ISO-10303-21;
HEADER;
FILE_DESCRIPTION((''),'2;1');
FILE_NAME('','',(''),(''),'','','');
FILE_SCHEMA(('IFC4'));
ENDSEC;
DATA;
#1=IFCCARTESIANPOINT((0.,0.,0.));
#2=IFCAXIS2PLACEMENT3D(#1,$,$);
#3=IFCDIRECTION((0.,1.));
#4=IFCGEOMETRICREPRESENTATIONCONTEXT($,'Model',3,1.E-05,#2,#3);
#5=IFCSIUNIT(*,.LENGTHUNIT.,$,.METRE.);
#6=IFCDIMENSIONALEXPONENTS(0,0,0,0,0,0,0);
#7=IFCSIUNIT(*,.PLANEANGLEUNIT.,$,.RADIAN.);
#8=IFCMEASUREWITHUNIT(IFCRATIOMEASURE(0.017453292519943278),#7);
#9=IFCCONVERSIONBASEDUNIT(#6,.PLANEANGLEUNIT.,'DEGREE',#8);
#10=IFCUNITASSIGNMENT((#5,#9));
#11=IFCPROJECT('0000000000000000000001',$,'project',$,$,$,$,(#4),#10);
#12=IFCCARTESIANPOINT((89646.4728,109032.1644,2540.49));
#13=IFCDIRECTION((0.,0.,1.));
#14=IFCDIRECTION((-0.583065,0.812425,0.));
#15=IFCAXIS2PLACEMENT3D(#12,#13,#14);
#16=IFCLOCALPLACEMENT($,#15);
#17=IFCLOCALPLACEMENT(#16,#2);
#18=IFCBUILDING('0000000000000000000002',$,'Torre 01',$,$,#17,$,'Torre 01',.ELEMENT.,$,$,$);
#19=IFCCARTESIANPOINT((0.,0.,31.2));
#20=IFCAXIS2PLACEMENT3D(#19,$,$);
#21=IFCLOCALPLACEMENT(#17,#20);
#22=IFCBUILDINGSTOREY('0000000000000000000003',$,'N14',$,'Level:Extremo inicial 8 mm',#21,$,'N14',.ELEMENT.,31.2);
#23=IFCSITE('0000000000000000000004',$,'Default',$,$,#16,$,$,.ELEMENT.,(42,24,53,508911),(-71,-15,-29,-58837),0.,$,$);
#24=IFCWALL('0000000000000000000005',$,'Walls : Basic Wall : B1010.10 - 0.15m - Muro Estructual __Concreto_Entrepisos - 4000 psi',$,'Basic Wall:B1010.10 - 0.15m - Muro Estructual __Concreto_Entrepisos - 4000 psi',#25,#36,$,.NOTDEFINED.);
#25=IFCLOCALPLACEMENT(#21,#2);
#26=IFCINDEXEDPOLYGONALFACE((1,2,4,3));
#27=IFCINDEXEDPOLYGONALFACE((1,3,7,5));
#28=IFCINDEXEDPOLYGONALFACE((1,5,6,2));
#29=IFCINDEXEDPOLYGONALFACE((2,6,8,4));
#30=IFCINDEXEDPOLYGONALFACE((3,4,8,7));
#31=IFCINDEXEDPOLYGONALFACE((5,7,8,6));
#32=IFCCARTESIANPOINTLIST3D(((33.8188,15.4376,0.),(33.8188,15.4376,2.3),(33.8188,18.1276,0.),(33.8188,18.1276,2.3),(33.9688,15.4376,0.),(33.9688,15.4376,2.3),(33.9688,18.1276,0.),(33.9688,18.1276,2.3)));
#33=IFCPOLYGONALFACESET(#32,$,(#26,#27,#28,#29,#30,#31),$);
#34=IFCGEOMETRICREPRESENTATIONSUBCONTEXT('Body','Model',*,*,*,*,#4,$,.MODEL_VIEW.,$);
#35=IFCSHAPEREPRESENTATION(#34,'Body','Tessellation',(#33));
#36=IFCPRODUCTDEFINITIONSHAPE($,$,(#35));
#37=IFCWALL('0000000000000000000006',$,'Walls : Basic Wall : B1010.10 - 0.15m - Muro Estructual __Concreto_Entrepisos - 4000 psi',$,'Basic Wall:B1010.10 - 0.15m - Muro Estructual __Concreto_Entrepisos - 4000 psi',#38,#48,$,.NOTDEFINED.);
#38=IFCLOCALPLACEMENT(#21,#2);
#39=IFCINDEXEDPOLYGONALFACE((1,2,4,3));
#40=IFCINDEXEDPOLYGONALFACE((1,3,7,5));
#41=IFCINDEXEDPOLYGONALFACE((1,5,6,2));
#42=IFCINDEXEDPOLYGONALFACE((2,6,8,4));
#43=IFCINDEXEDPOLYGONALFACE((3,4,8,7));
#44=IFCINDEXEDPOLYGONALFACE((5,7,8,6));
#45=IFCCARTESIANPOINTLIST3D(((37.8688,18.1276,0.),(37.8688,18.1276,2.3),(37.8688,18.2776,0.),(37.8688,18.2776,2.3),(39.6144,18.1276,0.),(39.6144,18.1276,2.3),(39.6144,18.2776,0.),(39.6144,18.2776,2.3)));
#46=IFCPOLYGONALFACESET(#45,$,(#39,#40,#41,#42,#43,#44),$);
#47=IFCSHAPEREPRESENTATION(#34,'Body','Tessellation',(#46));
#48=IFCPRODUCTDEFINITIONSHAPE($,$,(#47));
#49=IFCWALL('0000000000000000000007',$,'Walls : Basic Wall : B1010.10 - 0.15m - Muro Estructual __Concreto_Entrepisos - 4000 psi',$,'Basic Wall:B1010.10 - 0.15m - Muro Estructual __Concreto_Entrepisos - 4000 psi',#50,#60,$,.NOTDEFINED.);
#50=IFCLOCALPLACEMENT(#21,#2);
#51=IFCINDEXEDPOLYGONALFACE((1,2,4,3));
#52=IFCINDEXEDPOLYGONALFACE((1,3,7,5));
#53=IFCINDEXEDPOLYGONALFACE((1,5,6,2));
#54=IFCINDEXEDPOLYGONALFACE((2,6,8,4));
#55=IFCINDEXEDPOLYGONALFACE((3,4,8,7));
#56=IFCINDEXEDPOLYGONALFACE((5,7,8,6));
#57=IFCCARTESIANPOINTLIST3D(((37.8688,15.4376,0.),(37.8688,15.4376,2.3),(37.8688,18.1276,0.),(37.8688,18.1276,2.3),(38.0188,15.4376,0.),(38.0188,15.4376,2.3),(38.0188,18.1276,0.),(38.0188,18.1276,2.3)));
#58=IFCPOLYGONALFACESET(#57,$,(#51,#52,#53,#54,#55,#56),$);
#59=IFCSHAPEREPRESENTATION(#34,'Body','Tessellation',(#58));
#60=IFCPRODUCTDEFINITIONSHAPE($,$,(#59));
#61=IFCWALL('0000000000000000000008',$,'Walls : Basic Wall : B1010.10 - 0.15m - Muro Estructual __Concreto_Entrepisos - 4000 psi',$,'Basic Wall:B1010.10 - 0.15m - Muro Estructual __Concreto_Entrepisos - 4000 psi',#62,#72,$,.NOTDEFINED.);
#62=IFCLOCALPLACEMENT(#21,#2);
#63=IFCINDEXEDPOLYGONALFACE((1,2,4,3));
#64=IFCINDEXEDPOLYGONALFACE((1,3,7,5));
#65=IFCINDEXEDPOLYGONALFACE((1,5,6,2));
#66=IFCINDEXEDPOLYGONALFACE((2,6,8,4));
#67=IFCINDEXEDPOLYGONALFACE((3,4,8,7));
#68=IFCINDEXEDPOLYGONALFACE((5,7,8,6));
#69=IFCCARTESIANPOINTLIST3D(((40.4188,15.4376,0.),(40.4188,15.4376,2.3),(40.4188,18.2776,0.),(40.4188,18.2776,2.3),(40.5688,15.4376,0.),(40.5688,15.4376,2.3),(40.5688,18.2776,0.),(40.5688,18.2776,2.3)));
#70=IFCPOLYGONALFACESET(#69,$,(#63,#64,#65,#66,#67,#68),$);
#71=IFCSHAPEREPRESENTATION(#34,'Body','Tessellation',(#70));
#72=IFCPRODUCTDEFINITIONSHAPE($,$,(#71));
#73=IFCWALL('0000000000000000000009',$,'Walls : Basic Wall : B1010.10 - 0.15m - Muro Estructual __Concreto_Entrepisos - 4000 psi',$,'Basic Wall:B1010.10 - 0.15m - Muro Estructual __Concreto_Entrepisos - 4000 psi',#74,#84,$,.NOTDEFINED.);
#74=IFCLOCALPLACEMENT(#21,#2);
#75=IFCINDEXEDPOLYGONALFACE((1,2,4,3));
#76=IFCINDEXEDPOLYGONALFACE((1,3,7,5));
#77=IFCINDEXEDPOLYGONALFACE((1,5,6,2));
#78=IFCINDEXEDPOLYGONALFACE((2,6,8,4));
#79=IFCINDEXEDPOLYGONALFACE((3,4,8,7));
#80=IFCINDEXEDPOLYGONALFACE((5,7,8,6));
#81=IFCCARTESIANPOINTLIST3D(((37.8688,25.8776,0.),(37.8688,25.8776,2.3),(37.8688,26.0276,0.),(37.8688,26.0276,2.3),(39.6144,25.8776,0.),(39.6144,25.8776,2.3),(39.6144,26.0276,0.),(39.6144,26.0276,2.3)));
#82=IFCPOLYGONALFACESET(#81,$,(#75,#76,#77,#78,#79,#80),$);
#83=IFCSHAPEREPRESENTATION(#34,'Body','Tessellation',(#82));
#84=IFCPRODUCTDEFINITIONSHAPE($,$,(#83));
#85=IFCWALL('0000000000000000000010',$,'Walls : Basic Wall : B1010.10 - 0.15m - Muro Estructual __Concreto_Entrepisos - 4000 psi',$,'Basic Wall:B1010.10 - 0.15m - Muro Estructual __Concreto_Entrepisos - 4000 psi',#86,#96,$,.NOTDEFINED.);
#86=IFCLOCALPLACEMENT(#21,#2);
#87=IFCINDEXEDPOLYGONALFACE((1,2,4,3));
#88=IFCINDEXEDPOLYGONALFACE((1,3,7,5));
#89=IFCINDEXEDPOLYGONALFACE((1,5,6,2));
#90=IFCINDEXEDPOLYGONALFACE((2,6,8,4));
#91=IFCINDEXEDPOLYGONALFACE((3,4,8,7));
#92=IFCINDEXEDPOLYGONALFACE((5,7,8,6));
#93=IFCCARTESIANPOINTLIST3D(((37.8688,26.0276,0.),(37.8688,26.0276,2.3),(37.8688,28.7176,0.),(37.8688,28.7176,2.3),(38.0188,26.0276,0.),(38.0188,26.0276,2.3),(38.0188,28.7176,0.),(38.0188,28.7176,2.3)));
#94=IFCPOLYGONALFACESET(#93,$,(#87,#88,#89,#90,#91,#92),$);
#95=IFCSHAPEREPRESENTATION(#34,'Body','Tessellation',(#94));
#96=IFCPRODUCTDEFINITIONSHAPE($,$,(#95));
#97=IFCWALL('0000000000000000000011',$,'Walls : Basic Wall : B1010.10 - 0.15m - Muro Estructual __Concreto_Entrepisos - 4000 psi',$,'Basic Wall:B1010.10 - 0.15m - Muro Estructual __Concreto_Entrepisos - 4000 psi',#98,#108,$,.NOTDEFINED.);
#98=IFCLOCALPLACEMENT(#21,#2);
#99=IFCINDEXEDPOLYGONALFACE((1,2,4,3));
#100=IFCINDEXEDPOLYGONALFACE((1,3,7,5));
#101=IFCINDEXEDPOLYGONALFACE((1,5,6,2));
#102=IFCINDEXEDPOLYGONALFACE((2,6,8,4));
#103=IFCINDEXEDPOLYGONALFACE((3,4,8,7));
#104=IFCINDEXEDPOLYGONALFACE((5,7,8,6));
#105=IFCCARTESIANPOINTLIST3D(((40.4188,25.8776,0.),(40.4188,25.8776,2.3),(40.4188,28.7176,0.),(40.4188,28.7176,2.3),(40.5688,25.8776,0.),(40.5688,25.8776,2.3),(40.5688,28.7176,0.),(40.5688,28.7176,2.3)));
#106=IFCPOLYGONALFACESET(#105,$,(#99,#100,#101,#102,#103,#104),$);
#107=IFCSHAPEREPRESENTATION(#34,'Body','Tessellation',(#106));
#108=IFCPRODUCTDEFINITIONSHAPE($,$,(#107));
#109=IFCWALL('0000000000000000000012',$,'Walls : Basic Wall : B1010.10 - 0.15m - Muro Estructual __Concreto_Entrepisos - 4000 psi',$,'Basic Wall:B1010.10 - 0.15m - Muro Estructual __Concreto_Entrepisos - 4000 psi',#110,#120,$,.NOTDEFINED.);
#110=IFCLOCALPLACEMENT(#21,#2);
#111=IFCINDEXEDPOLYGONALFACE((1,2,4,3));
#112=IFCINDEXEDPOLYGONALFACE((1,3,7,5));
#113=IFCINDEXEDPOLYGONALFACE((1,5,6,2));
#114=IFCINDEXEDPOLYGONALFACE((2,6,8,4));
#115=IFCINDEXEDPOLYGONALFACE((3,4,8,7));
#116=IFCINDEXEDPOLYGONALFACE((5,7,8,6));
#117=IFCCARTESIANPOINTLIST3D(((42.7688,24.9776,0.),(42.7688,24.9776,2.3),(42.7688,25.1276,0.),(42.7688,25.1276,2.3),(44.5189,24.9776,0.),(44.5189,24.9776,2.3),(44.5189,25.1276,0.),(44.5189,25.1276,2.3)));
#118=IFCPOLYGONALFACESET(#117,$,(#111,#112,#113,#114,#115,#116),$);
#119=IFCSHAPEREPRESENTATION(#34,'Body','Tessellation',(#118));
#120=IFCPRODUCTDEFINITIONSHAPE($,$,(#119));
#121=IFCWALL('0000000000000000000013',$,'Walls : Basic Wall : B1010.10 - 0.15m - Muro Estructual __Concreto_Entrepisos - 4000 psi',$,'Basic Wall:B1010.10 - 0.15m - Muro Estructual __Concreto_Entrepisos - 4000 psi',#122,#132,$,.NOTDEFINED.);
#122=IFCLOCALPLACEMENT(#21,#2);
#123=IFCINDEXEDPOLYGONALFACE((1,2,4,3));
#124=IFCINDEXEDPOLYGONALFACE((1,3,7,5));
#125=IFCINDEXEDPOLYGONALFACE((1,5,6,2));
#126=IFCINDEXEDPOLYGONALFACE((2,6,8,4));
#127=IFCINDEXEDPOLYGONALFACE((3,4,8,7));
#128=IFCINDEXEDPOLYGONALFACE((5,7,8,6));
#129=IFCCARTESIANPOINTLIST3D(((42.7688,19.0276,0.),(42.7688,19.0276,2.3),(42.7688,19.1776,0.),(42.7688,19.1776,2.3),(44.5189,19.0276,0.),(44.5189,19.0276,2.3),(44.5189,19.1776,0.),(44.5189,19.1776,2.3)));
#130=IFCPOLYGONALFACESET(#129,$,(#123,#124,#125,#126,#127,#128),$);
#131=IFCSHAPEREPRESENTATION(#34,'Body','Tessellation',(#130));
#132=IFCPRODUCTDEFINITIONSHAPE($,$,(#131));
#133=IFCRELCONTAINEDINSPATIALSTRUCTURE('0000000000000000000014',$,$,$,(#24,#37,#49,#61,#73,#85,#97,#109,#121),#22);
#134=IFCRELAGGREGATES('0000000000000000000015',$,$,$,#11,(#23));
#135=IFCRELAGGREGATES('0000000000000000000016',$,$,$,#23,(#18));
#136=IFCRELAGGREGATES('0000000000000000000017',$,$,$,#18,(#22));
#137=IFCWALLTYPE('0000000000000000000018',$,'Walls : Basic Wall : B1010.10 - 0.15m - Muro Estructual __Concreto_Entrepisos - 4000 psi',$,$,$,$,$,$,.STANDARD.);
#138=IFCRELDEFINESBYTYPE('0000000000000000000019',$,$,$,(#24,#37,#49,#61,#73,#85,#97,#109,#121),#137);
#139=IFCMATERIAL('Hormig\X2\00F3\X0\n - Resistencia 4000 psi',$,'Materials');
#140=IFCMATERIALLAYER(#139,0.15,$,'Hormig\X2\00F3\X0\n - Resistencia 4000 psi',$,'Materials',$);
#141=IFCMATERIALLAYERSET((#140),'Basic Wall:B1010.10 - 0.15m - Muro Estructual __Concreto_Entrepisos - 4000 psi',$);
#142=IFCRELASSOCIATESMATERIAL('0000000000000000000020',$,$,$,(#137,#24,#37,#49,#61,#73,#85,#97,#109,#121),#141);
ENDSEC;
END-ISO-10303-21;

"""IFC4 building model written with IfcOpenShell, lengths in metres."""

from ifc_helpers import new_model, entity, si_unit, converted_unit, direction, frame, frame_2d, origin, place, context, subcontext, project, spatial, rectangle, extrude, material, layer, layer_set, layer_usage, type_object, element, save


model = new_model("IFC4")

# Units and contexts
model_context = context("Model", 3, precision=1e-05, world=origin(), true_north=direction((0.0, 1.0)))
body_context = subcontext(model_context, "Body", "Model", "MODEL_VIEW")
ifc_project = project(units=[si_unit("LENGTHUNIT", "METRE"), converted_unit("PLANEANGLEUNIT", "DEGREE", entity("IfcRatioMeasure", 0.017453292519943278), si_unit("PLANEANGLEUNIT", "RADIAN"), dimensions=[0, 0, 0, 0, 0, 0, 0])], contexts=[model_context])

# Site, building, storey
site_placement = place(None, frame((89646.4728, 109032.1644, 2540.49), z_axis=(0.0, 0.0, 1.0), x_axis=(-0.583065, 0.812425, 0.0)))
site = spatial("IfcSite", under=ifc_project, at=site_placement, Name="Default", CompositionType="ELEMENT", RefLatitude=(42, 24, 53, 508911), RefLongitude=(-71, -15, -29, -58837), RefElevation=0.0)
building_placement = place(site_placement, origin())
building = spatial("IfcBuilding", under=site, at=building_placement, Name="Torre 01", LongName="Torre 01", CompositionType="ELEMENT")
storey_placement = place(building_placement, frame((0.0, 0.0, 31.2)))
storey = spatial("IfcBuildingStorey", under=building, at=storey_placement, Name="N14", ObjectType="Level:Extremo inicial 8 mm", LongName="N14", CompositionType="ELEMENT", Elevation=31.2)

# Walls
ifc_material = material(Name="Hormigón - Resistencia 4000 psi", Category="Materials")
ifc_layer_1 = layer(ifc_material, 0.15, Name="Hormigón - Resistencia 4000 psi", Category="Materials")
ifc_layer_set_1 = layer_set([ifc_layer_1], Name="Basic Wall:B1010.10 - 0.15m - Muro Estructual __Concreto_Entrepisos - 4000 psi")
wall_type_1 = type_object("IfcWallType", Name="Walls : Basic Wall : B1010.10 - 0.15m - Muro Estructual __Concreto_Entrepisos - 4000 psi", PredefinedType="STANDARD", material=ifc_layer_set_1)
ifc_layer_usage_1 = layer_usage(ifc_layer_set_1, "AXIS2", "NEGATIVE", 0.075)
wall_1_placement = place(storey_placement, frame((33.8938, 18.1276, 0.0), z_axis=(0.0, 0.0, 1.0), x_axis=(0.0, -1.0, 0.0)))
element("IfcWall", 1, at=wall_1_placement, inside=storey, type_object=wall_type_1, material=ifc_layer_usage_1, Name="Walls : Basic Wall : B1010.10 - 0.15m - Muro Estructual __Concreto_Entrepisos - 4000 psi", ObjectType="Basic Wall:B1010.10 - 0.15m - Muro Estructual __Concreto_Entrepisos - 4000 psi", PredefinedType="NOTDEFINED", context=body_context, shape_type="SweptSolid", body=[
    extrude(rectangle(XDim=2.69, YDim=0.15, at=frame_2d((1.345, 0.0), x_axis=(-1.0, 0.0))), origin(), (0.0, 0.0, 1.0), 2.3),
])
ifc_layer_usage_2 = layer_usage(ifc_layer_set_1, "AXIS2", "NEGATIVE", 0.075)
wall_2_placement = place(storey_placement, frame((39.6144, 18.2026, 0.0), z_axis=(0.0, 0.0, 1.0), x_axis=(-1.0, 0.0, 0.0)))
element("IfcWall", 2, at=wall_2_placement, inside=storey, type_object=wall_type_1, material=ifc_layer_usage_2, Name="Walls : Basic Wall : B1010.10 - 0.15m - Muro Estructual __Concreto_Entrepisos - 4000 psi", ObjectType="Basic Wall:B1010.10 - 0.15m - Muro Estructual __Concreto_Entrepisos - 4000 psi", PredefinedType="NOTDEFINED", context=body_context, shape_type="SweptSolid", body=[
    extrude(rectangle(XDim=1.7455, YDim=0.15, at=frame_2d((0.8728, 0.0), x_axis=(-1.0, 0.0))), origin(), (0.0, 0.0, 1.0), 2.3),
])
ifc_layer_usage_3 = layer_usage(ifc_layer_set_1, "AXIS2", "NEGATIVE", 0.075)
wall_3_placement = place(storey_placement, frame((37.9438, 18.1276, 0.0), z_axis=(0.0, 0.0, 1.0), x_axis=(0.0, -1.0, 0.0)))
element("IfcWall", 3, at=wall_3_placement, inside=storey, type_object=wall_type_1, material=ifc_layer_usage_3, Name="Walls : Basic Wall : B1010.10 - 0.15m - Muro Estructual __Concreto_Entrepisos - 4000 psi", ObjectType="Basic Wall:B1010.10 - 0.15m - Muro Estructual __Concreto_Entrepisos - 4000 psi", PredefinedType="NOTDEFINED", context=body_context, shape_type="SweptSolid", body=[
    extrude(rectangle(XDim=2.69, YDim=0.15, at=frame_2d((1.345, 0.0), x_axis=(-1.0, 0.0))), origin(), (0.0, 0.0, 1.0), 2.3),
])
ifc_layer_usage_4 = layer_usage(ifc_layer_set_1, "AXIS2", "NEGATIVE", 0.075)
wall_4_placement = place(storey_placement, frame((40.4938, 18.2776, 0.0), z_axis=(0.0, 0.0, 1.0), x_axis=(0.0, -1.0, 0.0)))
element("IfcWall", 4, at=wall_4_placement, inside=storey, type_object=wall_type_1, material=ifc_layer_usage_4, Name="Walls : Basic Wall : B1010.10 - 0.15m - Muro Estructual __Concreto_Entrepisos - 4000 psi", ObjectType="Basic Wall:B1010.10 - 0.15m - Muro Estructual __Concreto_Entrepisos - 4000 psi", PredefinedType="NOTDEFINED", context=body_context, shape_type="SweptSolid", body=[
    extrude(rectangle(XDim=2.84, YDim=0.15, at=frame_2d((1.42, 0.0), x_axis=(-1.0, 0.0))), origin(), (0.0, 0.0, 1.0), 2.3),
])
ifc_layer_usage_5 = layer_usage(ifc_layer_set_1, "AXIS2", "POSITIVE", -0.075)
wall_5_placement = place(storey_placement, frame((39.6144, 25.9526, 0.0), z_axis=(0.0, 0.0, 1.0), x_axis=(-1.0, 0.0, 0.0)))
element("IfcWall", 5, at=wall_5_placement, inside=storey, type_object=wall_type_1, material=ifc_layer_usage_5, Name="Walls : Basic Wall : B1010.10 - 0.15m - Muro Estructual __Concreto_Entrepisos - 4000 psi", ObjectType="Basic Wall:B1010.10 - 0.15m - Muro Estructual __Concreto_Entrepisos - 4000 psi", PredefinedType="NOTDEFINED", context=body_context, shape_type="SweptSolid", body=[
    extrude(rectangle(XDim=1.7455, YDim=0.15, at=frame_2d((0.8728, 0.0), x_axis=(-1.0, 0.0))), origin(), (0.0, 0.0, 1.0), 2.3),
])
ifc_layer_usage_6 = layer_usage(ifc_layer_set_1, "AXIS2", "POSITIVE", -0.075)
wall_6_placement = place(storey_placement, frame((37.9438, 26.0276, 0.0), z_axis=(0.0, 0.0, 1.0), x_axis=(0.0, 1.0, 0.0)))
element("IfcWall", 6, at=wall_6_placement, inside=storey, type_object=wall_type_1, material=ifc_layer_usage_6, Name="Walls : Basic Wall : B1010.10 - 0.15m - Muro Estructual __Concreto_Entrepisos - 4000 psi", ObjectType="Basic Wall:B1010.10 - 0.15m - Muro Estructual __Concreto_Entrepisos - 4000 psi", PredefinedType="NOTDEFINED", context=body_context, shape_type="SweptSolid", body=[
    extrude(rectangle(XDim=2.69, YDim=0.15, at=frame_2d((1.345, 0.0), x_axis=(-1.0, 0.0))), origin(), (0.0, 0.0, 1.0), 2.3),
])
ifc_layer_usage_7 = layer_usage(ifc_layer_set_1, "AXIS2", "POSITIVE", -0.075)
wall_7_placement = place(storey_placement, frame((40.4938, 25.8776, 0.0), z_axis=(0.0, 0.0, 1.0), x_axis=(0.0, 1.0, 0.0)))
element("IfcWall", 7, at=wall_7_placement, inside=storey, type_object=wall_type_1, material=ifc_layer_usage_7, Name="Walls : Basic Wall : B1010.10 - 0.15m - Muro Estructual __Concreto_Entrepisos - 4000 psi", ObjectType="Basic Wall:B1010.10 - 0.15m - Muro Estructual __Concreto_Entrepisos - 4000 psi", PredefinedType="NOTDEFINED", context=body_context, shape_type="SweptSolid", body=[
    extrude(rectangle(XDim=2.84, YDim=0.15, at=frame_2d((1.42, 0.0), x_axis=(-1.0, 0.0))), origin(), (0.0, 0.0, 1.0), 2.3),
])
ifc_layer_usage_8 = layer_usage(ifc_layer_set_1, "AXIS2", "NEGATIVE", 0.075)
wall_8_placement = place(storey_placement, frame((42.7688, 25.0526, 0.0)))
element("IfcWall", 8, at=wall_8_placement, inside=storey, type_object=wall_type_1, material=ifc_layer_usage_8, Name="Walls : Basic Wall : B1010.10 - 0.15m - Muro Estructual __Concreto_Entrepisos - 4000 psi", ObjectType="Basic Wall:B1010.10 - 0.15m - Muro Estructual __Concreto_Entrepisos - 4000 psi", PredefinedType="NOTDEFINED", context=body_context, shape_type="SweptSolid", body=[
    extrude(rectangle(XDim=1.75, YDim=0.15, at=frame_2d((0.875, 0.0), x_axis=(-1.0, 0.0))), origin(), (0.0, 0.0, 1.0), 2.3),
])
ifc_layer_usage_9 = layer_usage(ifc_layer_set_1, "AXIS2", "POSITIVE", -0.075)
wall_9_placement = place(storey_placement, frame((42.7688, 19.1026, 0.0)))
element("IfcWall", 9, at=wall_9_placement, inside=storey, type_object=wall_type_1, material=ifc_layer_usage_9, Name="Walls : Basic Wall : B1010.10 - 0.15m - Muro Estructual __Concreto_Entrepisos - 4000 psi", ObjectType="Basic Wall:B1010.10 - 0.15m - Muro Estructual __Concreto_Entrepisos - 4000 psi", PredefinedType="NOTDEFINED", context=body_context, shape_type="SweptSolid", body=[
    extrude(rectangle(XDim=1.75, YDim=0.15, at=frame_2d((0.875, 0.0), x_axis=(-1.0, 0.0))), origin(), (0.0, 0.0, 1.0), 2.3),
])

save(model, "model.ifc")
